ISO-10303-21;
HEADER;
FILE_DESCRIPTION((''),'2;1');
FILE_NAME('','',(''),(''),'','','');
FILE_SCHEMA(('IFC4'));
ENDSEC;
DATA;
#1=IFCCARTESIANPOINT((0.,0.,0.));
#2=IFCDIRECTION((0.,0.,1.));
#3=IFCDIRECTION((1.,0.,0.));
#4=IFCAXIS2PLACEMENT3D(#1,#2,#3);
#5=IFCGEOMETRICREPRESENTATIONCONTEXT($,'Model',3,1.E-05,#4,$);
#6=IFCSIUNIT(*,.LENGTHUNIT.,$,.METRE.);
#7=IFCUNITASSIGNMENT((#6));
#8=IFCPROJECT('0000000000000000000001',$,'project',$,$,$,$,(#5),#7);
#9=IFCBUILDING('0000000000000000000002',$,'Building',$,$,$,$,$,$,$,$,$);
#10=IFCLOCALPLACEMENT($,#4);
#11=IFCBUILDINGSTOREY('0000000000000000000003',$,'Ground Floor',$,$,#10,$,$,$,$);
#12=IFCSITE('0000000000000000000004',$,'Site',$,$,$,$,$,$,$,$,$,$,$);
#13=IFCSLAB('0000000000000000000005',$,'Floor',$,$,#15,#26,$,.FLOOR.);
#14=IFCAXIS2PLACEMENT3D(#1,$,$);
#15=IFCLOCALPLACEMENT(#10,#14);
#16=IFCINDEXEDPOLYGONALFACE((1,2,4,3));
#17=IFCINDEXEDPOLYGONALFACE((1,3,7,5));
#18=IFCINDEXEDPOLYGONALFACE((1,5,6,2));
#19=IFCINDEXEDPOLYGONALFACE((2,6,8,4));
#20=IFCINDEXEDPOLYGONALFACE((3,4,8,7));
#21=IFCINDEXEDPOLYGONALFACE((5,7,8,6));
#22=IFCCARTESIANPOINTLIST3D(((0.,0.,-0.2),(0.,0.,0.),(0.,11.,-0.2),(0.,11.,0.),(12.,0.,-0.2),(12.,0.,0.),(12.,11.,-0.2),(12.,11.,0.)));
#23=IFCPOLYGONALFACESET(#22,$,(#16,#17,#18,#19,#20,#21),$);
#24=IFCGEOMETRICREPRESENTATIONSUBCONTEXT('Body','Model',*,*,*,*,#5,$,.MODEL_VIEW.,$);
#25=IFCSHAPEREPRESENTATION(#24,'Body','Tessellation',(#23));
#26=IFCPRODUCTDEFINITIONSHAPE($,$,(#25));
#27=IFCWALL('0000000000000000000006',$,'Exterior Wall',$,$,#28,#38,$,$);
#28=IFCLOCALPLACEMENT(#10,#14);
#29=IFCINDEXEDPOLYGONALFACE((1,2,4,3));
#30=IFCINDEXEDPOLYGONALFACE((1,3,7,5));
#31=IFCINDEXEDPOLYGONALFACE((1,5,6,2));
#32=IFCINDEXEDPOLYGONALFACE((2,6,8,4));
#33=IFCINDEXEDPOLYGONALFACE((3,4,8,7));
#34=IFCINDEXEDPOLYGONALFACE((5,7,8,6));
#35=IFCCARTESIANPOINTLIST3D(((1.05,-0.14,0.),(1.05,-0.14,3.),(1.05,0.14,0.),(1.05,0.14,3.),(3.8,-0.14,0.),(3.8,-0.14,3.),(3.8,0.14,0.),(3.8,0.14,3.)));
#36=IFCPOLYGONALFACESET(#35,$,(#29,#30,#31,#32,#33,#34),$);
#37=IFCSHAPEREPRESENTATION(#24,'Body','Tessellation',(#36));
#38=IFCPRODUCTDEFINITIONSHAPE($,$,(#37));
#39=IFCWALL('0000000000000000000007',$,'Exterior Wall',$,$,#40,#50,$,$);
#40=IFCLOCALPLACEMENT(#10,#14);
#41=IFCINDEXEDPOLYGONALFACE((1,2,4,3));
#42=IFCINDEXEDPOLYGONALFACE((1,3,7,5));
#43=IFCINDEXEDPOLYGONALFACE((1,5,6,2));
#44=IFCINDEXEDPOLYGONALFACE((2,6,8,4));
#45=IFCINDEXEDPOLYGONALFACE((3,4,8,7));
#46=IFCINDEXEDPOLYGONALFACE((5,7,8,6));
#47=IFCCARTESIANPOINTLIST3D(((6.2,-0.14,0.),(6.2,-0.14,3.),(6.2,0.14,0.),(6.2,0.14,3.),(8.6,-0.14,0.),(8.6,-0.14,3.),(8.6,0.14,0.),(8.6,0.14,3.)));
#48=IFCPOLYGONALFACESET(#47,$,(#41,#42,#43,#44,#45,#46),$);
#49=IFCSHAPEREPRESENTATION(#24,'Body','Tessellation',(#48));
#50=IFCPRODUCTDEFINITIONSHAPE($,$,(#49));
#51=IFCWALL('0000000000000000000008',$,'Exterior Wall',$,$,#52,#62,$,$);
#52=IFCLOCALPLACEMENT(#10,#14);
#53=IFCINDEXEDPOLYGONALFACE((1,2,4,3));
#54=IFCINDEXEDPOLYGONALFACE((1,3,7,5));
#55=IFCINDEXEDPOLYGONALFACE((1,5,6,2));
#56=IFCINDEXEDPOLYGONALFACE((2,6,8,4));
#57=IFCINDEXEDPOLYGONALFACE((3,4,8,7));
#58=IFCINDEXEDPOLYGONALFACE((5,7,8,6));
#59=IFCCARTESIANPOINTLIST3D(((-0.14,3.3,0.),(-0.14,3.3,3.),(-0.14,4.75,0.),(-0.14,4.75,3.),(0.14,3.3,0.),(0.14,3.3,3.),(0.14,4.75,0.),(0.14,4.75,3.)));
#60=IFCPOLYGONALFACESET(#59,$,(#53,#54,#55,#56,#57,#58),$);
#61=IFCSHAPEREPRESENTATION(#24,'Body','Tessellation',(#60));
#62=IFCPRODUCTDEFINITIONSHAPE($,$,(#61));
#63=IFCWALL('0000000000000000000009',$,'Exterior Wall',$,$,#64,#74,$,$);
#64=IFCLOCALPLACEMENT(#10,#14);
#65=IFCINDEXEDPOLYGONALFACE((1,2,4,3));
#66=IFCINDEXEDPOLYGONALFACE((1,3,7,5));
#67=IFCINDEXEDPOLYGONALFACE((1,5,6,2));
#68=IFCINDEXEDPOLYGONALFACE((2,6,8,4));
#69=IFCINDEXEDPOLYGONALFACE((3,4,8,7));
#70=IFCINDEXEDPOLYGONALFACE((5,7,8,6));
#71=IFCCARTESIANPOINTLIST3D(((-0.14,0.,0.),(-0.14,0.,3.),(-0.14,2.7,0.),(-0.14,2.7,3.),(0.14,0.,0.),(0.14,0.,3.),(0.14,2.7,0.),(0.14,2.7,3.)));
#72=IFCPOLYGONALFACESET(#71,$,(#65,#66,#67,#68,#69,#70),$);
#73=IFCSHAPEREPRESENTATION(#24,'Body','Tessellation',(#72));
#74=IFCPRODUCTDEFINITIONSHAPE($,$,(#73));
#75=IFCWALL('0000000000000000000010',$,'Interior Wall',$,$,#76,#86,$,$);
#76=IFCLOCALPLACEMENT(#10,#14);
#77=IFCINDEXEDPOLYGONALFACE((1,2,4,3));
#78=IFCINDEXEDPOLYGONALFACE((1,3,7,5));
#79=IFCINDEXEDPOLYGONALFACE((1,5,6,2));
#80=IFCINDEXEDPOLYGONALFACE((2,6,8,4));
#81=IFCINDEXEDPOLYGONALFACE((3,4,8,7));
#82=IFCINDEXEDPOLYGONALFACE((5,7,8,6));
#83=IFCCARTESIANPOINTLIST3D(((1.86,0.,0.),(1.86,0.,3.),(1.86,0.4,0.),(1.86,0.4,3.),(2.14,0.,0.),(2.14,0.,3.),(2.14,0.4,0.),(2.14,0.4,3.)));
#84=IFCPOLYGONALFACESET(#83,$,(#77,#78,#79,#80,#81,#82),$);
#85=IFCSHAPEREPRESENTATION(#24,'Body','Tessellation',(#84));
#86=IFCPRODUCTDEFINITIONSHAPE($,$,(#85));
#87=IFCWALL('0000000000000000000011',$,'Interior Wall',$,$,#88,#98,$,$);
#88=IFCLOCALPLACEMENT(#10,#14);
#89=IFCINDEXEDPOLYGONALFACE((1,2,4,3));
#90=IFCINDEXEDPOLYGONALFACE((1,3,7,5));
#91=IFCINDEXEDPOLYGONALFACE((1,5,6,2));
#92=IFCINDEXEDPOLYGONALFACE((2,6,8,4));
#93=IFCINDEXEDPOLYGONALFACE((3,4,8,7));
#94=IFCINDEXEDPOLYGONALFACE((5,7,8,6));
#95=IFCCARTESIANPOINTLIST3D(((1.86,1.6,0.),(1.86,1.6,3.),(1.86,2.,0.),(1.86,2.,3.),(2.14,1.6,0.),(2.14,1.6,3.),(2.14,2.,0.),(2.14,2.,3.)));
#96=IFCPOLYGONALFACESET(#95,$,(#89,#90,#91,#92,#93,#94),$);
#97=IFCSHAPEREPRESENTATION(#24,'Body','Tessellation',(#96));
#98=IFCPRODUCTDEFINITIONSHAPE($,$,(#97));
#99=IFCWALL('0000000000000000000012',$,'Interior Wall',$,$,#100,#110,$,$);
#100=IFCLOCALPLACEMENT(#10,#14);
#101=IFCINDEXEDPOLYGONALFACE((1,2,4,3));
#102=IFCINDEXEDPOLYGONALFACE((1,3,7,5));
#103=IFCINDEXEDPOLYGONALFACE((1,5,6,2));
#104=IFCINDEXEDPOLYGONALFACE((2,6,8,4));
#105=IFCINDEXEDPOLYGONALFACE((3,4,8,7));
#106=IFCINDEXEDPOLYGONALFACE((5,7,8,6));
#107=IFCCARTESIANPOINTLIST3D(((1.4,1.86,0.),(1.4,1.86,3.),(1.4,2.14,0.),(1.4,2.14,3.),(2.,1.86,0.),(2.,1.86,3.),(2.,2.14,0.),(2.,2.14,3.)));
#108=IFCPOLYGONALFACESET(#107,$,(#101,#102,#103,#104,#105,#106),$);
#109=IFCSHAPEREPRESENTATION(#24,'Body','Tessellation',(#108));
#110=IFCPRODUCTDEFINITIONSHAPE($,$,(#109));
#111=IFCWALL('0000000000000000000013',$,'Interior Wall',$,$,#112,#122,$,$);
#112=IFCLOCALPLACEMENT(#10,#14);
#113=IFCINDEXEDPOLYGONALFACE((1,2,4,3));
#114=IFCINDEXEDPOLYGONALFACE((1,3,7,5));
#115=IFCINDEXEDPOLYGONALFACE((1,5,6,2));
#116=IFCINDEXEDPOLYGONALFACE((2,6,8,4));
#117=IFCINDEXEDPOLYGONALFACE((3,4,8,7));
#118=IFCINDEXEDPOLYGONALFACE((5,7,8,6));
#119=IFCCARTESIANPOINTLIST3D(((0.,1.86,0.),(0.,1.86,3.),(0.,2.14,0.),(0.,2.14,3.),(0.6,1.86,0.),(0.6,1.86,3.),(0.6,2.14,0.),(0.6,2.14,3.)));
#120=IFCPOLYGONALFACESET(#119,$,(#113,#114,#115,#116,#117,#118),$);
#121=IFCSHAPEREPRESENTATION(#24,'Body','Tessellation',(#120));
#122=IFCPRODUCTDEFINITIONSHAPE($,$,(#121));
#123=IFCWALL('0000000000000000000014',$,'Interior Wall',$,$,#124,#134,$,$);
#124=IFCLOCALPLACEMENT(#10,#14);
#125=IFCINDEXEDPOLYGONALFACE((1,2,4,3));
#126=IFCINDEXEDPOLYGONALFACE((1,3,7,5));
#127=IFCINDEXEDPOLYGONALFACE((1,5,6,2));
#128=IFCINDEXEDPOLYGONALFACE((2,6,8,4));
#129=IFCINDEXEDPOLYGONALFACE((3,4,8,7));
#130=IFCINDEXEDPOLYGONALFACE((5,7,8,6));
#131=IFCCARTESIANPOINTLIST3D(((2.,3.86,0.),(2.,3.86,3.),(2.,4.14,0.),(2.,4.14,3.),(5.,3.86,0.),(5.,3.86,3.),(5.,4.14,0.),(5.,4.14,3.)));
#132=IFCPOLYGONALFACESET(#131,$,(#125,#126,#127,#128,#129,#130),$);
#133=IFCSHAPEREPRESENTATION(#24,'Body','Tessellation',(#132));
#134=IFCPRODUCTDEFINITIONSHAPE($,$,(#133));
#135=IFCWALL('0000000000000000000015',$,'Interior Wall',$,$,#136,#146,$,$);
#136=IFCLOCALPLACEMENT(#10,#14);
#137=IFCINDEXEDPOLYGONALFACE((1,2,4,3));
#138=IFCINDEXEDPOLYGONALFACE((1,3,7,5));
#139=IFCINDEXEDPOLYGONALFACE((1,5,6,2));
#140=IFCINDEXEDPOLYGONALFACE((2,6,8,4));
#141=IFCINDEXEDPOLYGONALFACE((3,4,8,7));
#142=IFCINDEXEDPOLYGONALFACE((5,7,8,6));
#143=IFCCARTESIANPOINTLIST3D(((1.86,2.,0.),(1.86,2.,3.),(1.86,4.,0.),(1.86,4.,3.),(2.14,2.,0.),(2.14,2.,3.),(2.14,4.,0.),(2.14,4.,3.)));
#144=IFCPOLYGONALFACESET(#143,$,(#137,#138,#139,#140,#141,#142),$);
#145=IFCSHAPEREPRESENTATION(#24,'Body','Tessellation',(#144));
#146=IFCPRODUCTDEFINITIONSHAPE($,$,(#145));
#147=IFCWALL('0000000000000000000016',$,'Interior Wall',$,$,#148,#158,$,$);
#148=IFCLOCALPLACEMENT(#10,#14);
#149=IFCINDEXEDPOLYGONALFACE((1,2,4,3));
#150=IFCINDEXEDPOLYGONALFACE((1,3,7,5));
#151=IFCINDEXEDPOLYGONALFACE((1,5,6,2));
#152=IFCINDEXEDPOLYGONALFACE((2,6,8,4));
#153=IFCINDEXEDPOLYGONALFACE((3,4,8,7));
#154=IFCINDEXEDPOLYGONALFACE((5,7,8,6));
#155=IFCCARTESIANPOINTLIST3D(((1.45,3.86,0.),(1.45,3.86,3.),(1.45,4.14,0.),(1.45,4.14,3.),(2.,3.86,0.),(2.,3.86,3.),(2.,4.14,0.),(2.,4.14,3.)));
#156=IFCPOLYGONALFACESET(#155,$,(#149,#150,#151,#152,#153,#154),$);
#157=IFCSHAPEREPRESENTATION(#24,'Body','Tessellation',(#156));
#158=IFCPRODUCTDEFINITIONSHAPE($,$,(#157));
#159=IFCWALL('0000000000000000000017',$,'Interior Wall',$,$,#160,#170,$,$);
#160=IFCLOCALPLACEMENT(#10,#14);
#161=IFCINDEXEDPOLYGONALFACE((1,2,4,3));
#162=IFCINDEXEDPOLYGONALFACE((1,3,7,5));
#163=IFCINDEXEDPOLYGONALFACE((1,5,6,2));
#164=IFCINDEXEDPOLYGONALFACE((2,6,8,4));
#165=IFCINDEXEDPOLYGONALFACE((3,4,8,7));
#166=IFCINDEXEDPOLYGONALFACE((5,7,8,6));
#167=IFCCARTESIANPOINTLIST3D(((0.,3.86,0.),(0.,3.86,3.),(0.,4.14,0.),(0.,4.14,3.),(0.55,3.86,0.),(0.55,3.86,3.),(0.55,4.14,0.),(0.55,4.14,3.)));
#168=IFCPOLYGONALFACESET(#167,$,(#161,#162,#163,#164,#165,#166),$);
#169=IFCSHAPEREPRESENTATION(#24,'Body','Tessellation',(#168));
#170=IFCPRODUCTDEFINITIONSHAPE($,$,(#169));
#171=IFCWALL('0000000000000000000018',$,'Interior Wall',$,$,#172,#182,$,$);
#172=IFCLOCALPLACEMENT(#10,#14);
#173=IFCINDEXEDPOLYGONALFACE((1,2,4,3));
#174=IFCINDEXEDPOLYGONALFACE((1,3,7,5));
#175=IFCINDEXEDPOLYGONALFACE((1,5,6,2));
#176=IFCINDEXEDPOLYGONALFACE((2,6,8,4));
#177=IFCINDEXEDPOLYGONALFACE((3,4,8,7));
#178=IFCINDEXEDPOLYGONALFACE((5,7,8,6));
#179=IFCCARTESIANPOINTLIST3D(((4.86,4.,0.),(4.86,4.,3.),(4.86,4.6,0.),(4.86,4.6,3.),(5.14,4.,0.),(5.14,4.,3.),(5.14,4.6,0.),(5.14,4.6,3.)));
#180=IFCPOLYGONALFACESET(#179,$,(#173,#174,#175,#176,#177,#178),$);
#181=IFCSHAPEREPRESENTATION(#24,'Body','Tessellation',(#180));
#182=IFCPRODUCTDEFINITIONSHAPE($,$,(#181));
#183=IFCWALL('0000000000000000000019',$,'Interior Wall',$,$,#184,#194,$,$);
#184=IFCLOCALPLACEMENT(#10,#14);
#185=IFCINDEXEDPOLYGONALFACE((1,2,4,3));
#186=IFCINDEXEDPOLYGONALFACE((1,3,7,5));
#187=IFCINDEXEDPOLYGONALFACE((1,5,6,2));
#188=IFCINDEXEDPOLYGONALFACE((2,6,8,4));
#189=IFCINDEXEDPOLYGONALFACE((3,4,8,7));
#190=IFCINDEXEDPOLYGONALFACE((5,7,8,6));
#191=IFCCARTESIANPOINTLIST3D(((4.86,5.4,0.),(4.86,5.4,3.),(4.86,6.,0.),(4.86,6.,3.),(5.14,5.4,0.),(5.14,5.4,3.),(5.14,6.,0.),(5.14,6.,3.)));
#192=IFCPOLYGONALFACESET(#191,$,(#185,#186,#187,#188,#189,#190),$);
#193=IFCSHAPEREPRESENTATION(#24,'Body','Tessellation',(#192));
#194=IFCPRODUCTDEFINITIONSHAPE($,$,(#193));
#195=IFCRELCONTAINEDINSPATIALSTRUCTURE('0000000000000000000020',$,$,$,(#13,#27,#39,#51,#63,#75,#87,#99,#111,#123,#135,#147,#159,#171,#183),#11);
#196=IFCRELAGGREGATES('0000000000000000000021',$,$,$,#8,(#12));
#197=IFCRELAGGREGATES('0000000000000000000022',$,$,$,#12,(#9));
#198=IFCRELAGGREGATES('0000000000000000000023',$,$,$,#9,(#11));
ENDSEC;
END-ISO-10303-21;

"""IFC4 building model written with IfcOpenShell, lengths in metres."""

from ifc_helpers import new_model, si_unit, frame, origin_with_axes, place, context, subcontext, project, spatial, indexed_curve, outline, extrude, element, save


model = new_model("IFC4")

# Units and contexts
model_context = context("Model", 3, precision=1e-05, world=origin_with_axes())
body_context = subcontext(model_context, "Body", "Model", "MODEL_VIEW")
ifc_project = project(units=[si_unit("LENGTHUNIT", "METRE")], contexts=[model_context])

# Site, building, storey
site = spatial("IfcSite", under=ifc_project, Name="Site")
building = spatial("IfcBuilding", under=site, Name="Building")
storey_placement = place(None, origin_with_axes())
storey = spatial("IfcBuildingStorey", under=building, at=storey_placement, Name="Ground Floor")

# Slab
slab_placement = place(storey_placement, frame((0.0, 0.0, -0.2), z_axis=(0.0, 0.0, 1.0), x_axis=(1.0, 0.0, 0.0)))
element("IfcSlab", 1, at=slab_placement, inside=storey, Name="Floor", PredefinedType="FLOOR", context=body_context, shape_type="SweptSolid", body=[
    extrude(outline(indexed_curve([(0.0, 0.0), (12.0, 0.0), (12.0, 11.0), (0.0, 11.0)])), None, (0.0, 0.0, 1.0), 0.2),
])

# Walls
wall_1_placement = place(storey_placement, frame((1.05, 0.0, 0.0), z_axis=(0.0, 0.0, 1.0), x_axis=(1.0, 0.0, 0.0)))
element("IfcWall", 2, at=wall_1_placement, inside=storey, Name="Exterior Wall", context=body_context, shape_type="SweptSolid", body=[
    extrude(outline(indexed_curve([(0.0, 0.0), (0.0, 0.28), (2.75, 0.28), (2.75, 0.0), (0.0, 0.0)], self_intersect=False)), frame((0.0, -0.14, 0.0), z_axis=(0.0, 0.0, 1.0), x_axis=(1.0, 0.0, 0.0)), (0.0, 0.0, 1.0), 3.0),
])
wall_2_placement = place(storey_placement, frame((6.2, 0.0, 0.0), z_axis=(0.0, 0.0, 1.0), x_axis=(1.0, 0.0, 0.0)))
element("IfcWall", 3, at=wall_2_placement, inside=storey, Name="Exterior Wall", context=body_context, shape_type="SweptSolid", body=[
    extrude(outline(indexed_curve([(0.0, 0.0), (0.0, 0.28), (2.4, 0.28), (2.4, 0.0), (0.0, 0.0)], self_intersect=False)), frame((0.0, -0.14, 0.0), z_axis=(0.0, 0.0, 1.0), x_axis=(1.0, 0.0, 0.0)), (0.0, 0.0, 1.0), 3.0),
])
wall_3_placement = place(storey_placement, frame((0.0, 4.75, 0.0), z_axis=(0.0, 0.0, 1.0), x_axis=(0.0, -1.0, 0.0)))
element("IfcWall", 4, at=wall_3_placement, inside=storey, Name="Exterior Wall", context=body_context, shape_type="SweptSolid", body=[
    extrude(outline(indexed_curve([(0.0, 0.0), (0.0, 0.28), (1.45, 0.28), (1.45, 0.0), (0.0, 0.0)], self_intersect=False)), frame((0.0, -0.14, 0.0), z_axis=(0.0, 0.0, 1.0), x_axis=(1.0, 0.0, 0.0)), (0.0, 0.0, 1.0), 3.0),
])
wall_4_placement = place(storey_placement, frame((0.0, 2.7, 0.0), z_axis=(0.0, 0.0, 1.0), x_axis=(0.0, -1.0, 0.0)))
element("IfcWall", 5, at=wall_4_placement, inside=storey, Name="Exterior Wall", context=body_context, shape_type="SweptSolid", body=[
    extrude(outline(indexed_curve([(0.0, 0.0), (0.0, 0.28), (2.7, 0.28), (2.7, 0.0), (0.0, 0.0)], self_intersect=False)), frame((0.0, -0.14, 0.0), z_axis=(0.0, 0.0, 1.0), x_axis=(1.0, 0.0, 0.0)), (0.0, 0.0, 1.0), 3.0),
])
wall_5_placement = place(storey_placement, frame((2.0, 0.0, 0.0), z_axis=(0.0, 0.0, 1.0), x_axis=(0.0, 1.0, 0.0)))
element("IfcWall", 6, at=wall_5_placement, inside=storey, Name="Interior Wall", context=body_context, shape_type="SweptSolid", body=[
    extrude(outline(indexed_curve([(0.0, 0.0), (0.0, 0.28), (0.4, 0.28), (0.4, 0.0), (0.0, 0.0)], self_intersect=False)), frame((0.0, -0.14, 0.0), z_axis=(0.0, 0.0, 1.0), x_axis=(1.0, 0.0, 0.0)), (0.0, 0.0, 1.0), 3.0),
])
wall_6_placement = place(storey_placement, frame((2.0, 1.6, 0.0), z_axis=(0.0, 0.0, 1.0), x_axis=(0.0, 1.0, 0.0)))
element("IfcWall", 7, at=wall_6_placement, inside=storey, Name="Interior Wall", context=body_context, shape_type="SweptSolid", body=[
    extrude(outline(indexed_curve([(0.0, 0.0), (0.0, 0.28), (0.4, 0.28), (0.4, 0.0), (0.0, 0.0)], self_intersect=False)), frame((0.0, -0.14, 0.0), z_axis=(0.0, 0.0, 1.0), x_axis=(1.0, 0.0, 0.0)), (0.0, 0.0, 1.0), 3.0),
])
for number, where, z_axis, x_axis, name in (
    (8, (2.0, 2.0, 0.0), (0.0, 0.0, 1.0), (-1.0, 0.0, 0.0), "Interior Wall"),
    (9, (0.6, 2.0, 0.0), (0.0, 0.0, 1.0), (-1.0, 0.0, 0.0), "Interior Wall"),
):
    element("IfcWall", number, at=place(storey_placement, frame(where, z_axis=z_axis, x_axis=x_axis)), inside=storey, Name=name, context=body_context, shape_type="SweptSolid", body=[
        extrude(outline(indexed_curve([(0.0, 0.0), (0.0, 0.28), (0.6, 0.28), (0.6, 0.0), (0.0, 0.0)], self_intersect=False)), frame((0.0, -0.14, 0.0), z_axis=(0.0, 0.0, 1.0), x_axis=(1.0, 0.0, 0.0)), (0.0, 0.0, 1.0), 3.0),
    ])
wall_7_placement = place(storey_placement, frame((5.0, 4.0, 0.0), z_axis=(0.0, 0.0, 1.0), x_axis=(-1.0, 0.0, 0.0)))
element("IfcWall", 10, at=wall_7_placement, inside=storey, Name="Interior Wall", context=body_context, shape_type="SweptSolid", body=[
    extrude(outline(indexed_curve([(0.0, 0.0), (0.0, 0.28), (3.0, 0.28), (3.0, 0.0), (0.0, 0.0)], self_intersect=False)), frame((0.0, -0.14, 0.0), z_axis=(0.0, 0.0, 1.0), x_axis=(1.0, 0.0, 0.0)), (0.0, 0.0, 1.0), 3.0),
])
wall_8_placement = place(storey_placement, frame((2.0, 4.0, 0.0), z_axis=(0.0, 0.0, 1.0), x_axis=(0.0, -1.0, 0.0)))
element("IfcWall", 11, at=wall_8_placement, inside=storey, Name="Interior Wall", context=body_context, shape_type="SweptSolid", body=[
    extrude(outline(indexed_curve([(0.0, 0.0), (0.0, 0.28), (2.0, 0.28), (2.0, 0.0), (0.0, 0.0)], self_intersect=False)), frame((0.0, -0.14, 0.0), z_axis=(0.0, 0.0, 1.0), x_axis=(1.0, 0.0, 0.0)), (0.0, 0.0, 1.0), 3.0),
])
for number, where, z_axis, x_axis, name in (
    (12, (2.0, 4.0, 0.0), (0.0, 0.0, 1.0), (-1.0, 0.0, 0.0), "Interior Wall"),
    (13, (0.55, 4.0, 0.0), (0.0, 0.0, 1.0), (-1.0, 0.0, 0.0), "Interior Wall"),
):
    element("IfcWall", number, at=place(storey_placement, frame(where, z_axis=z_axis, x_axis=x_axis)), inside=storey, Name=name, context=body_context, shape_type="SweptSolid", body=[
        extrude(outline(indexed_curve([(0.0, 0.0), (0.0, 0.28), (0.55, 0.28), (0.55, 0.0), (0.0, 0.0)], self_intersect=False)), frame((0.0, -0.14, 0.0), z_axis=(0.0, 0.0, 1.0), x_axis=(1.0, 0.0, 0.0)), (0.0, 0.0, 1.0), 3.0),
    ])
for number, where, z_axis, x_axis, name in (
    (14, (5.0, 4.0, 0.0), (0.0, 0.0, 1.0), (0.0, 1.0, 0.0), "Interior Wall"),
    (15, (5.0, 5.4, 0.0), (0.0, 0.0, 1.0), (0.0, 1.0, 0.0), "Interior Wall"),
):
    element("IfcWall", number, at=place(storey_placement, frame(where, z_axis=z_axis, x_axis=x_axis)), inside=storey, Name=name, context=body_context, shape_type="SweptSolid", body=[
        extrude(outline(indexed_curve([(0.0, 0.0), (0.0, 0.28), (0.6, 0.28), (0.6, 0.0), (0.0, 0.0)], self_intersect=False)), frame((0.0, -0.14, 0.0), z_axis=(0.0, 0.0, 1.0), x_axis=(1.0, 0.0, 0.0)), (0.0, 0.0, 1.0), 3.0),
    ])

save(model, "model.ifc")
